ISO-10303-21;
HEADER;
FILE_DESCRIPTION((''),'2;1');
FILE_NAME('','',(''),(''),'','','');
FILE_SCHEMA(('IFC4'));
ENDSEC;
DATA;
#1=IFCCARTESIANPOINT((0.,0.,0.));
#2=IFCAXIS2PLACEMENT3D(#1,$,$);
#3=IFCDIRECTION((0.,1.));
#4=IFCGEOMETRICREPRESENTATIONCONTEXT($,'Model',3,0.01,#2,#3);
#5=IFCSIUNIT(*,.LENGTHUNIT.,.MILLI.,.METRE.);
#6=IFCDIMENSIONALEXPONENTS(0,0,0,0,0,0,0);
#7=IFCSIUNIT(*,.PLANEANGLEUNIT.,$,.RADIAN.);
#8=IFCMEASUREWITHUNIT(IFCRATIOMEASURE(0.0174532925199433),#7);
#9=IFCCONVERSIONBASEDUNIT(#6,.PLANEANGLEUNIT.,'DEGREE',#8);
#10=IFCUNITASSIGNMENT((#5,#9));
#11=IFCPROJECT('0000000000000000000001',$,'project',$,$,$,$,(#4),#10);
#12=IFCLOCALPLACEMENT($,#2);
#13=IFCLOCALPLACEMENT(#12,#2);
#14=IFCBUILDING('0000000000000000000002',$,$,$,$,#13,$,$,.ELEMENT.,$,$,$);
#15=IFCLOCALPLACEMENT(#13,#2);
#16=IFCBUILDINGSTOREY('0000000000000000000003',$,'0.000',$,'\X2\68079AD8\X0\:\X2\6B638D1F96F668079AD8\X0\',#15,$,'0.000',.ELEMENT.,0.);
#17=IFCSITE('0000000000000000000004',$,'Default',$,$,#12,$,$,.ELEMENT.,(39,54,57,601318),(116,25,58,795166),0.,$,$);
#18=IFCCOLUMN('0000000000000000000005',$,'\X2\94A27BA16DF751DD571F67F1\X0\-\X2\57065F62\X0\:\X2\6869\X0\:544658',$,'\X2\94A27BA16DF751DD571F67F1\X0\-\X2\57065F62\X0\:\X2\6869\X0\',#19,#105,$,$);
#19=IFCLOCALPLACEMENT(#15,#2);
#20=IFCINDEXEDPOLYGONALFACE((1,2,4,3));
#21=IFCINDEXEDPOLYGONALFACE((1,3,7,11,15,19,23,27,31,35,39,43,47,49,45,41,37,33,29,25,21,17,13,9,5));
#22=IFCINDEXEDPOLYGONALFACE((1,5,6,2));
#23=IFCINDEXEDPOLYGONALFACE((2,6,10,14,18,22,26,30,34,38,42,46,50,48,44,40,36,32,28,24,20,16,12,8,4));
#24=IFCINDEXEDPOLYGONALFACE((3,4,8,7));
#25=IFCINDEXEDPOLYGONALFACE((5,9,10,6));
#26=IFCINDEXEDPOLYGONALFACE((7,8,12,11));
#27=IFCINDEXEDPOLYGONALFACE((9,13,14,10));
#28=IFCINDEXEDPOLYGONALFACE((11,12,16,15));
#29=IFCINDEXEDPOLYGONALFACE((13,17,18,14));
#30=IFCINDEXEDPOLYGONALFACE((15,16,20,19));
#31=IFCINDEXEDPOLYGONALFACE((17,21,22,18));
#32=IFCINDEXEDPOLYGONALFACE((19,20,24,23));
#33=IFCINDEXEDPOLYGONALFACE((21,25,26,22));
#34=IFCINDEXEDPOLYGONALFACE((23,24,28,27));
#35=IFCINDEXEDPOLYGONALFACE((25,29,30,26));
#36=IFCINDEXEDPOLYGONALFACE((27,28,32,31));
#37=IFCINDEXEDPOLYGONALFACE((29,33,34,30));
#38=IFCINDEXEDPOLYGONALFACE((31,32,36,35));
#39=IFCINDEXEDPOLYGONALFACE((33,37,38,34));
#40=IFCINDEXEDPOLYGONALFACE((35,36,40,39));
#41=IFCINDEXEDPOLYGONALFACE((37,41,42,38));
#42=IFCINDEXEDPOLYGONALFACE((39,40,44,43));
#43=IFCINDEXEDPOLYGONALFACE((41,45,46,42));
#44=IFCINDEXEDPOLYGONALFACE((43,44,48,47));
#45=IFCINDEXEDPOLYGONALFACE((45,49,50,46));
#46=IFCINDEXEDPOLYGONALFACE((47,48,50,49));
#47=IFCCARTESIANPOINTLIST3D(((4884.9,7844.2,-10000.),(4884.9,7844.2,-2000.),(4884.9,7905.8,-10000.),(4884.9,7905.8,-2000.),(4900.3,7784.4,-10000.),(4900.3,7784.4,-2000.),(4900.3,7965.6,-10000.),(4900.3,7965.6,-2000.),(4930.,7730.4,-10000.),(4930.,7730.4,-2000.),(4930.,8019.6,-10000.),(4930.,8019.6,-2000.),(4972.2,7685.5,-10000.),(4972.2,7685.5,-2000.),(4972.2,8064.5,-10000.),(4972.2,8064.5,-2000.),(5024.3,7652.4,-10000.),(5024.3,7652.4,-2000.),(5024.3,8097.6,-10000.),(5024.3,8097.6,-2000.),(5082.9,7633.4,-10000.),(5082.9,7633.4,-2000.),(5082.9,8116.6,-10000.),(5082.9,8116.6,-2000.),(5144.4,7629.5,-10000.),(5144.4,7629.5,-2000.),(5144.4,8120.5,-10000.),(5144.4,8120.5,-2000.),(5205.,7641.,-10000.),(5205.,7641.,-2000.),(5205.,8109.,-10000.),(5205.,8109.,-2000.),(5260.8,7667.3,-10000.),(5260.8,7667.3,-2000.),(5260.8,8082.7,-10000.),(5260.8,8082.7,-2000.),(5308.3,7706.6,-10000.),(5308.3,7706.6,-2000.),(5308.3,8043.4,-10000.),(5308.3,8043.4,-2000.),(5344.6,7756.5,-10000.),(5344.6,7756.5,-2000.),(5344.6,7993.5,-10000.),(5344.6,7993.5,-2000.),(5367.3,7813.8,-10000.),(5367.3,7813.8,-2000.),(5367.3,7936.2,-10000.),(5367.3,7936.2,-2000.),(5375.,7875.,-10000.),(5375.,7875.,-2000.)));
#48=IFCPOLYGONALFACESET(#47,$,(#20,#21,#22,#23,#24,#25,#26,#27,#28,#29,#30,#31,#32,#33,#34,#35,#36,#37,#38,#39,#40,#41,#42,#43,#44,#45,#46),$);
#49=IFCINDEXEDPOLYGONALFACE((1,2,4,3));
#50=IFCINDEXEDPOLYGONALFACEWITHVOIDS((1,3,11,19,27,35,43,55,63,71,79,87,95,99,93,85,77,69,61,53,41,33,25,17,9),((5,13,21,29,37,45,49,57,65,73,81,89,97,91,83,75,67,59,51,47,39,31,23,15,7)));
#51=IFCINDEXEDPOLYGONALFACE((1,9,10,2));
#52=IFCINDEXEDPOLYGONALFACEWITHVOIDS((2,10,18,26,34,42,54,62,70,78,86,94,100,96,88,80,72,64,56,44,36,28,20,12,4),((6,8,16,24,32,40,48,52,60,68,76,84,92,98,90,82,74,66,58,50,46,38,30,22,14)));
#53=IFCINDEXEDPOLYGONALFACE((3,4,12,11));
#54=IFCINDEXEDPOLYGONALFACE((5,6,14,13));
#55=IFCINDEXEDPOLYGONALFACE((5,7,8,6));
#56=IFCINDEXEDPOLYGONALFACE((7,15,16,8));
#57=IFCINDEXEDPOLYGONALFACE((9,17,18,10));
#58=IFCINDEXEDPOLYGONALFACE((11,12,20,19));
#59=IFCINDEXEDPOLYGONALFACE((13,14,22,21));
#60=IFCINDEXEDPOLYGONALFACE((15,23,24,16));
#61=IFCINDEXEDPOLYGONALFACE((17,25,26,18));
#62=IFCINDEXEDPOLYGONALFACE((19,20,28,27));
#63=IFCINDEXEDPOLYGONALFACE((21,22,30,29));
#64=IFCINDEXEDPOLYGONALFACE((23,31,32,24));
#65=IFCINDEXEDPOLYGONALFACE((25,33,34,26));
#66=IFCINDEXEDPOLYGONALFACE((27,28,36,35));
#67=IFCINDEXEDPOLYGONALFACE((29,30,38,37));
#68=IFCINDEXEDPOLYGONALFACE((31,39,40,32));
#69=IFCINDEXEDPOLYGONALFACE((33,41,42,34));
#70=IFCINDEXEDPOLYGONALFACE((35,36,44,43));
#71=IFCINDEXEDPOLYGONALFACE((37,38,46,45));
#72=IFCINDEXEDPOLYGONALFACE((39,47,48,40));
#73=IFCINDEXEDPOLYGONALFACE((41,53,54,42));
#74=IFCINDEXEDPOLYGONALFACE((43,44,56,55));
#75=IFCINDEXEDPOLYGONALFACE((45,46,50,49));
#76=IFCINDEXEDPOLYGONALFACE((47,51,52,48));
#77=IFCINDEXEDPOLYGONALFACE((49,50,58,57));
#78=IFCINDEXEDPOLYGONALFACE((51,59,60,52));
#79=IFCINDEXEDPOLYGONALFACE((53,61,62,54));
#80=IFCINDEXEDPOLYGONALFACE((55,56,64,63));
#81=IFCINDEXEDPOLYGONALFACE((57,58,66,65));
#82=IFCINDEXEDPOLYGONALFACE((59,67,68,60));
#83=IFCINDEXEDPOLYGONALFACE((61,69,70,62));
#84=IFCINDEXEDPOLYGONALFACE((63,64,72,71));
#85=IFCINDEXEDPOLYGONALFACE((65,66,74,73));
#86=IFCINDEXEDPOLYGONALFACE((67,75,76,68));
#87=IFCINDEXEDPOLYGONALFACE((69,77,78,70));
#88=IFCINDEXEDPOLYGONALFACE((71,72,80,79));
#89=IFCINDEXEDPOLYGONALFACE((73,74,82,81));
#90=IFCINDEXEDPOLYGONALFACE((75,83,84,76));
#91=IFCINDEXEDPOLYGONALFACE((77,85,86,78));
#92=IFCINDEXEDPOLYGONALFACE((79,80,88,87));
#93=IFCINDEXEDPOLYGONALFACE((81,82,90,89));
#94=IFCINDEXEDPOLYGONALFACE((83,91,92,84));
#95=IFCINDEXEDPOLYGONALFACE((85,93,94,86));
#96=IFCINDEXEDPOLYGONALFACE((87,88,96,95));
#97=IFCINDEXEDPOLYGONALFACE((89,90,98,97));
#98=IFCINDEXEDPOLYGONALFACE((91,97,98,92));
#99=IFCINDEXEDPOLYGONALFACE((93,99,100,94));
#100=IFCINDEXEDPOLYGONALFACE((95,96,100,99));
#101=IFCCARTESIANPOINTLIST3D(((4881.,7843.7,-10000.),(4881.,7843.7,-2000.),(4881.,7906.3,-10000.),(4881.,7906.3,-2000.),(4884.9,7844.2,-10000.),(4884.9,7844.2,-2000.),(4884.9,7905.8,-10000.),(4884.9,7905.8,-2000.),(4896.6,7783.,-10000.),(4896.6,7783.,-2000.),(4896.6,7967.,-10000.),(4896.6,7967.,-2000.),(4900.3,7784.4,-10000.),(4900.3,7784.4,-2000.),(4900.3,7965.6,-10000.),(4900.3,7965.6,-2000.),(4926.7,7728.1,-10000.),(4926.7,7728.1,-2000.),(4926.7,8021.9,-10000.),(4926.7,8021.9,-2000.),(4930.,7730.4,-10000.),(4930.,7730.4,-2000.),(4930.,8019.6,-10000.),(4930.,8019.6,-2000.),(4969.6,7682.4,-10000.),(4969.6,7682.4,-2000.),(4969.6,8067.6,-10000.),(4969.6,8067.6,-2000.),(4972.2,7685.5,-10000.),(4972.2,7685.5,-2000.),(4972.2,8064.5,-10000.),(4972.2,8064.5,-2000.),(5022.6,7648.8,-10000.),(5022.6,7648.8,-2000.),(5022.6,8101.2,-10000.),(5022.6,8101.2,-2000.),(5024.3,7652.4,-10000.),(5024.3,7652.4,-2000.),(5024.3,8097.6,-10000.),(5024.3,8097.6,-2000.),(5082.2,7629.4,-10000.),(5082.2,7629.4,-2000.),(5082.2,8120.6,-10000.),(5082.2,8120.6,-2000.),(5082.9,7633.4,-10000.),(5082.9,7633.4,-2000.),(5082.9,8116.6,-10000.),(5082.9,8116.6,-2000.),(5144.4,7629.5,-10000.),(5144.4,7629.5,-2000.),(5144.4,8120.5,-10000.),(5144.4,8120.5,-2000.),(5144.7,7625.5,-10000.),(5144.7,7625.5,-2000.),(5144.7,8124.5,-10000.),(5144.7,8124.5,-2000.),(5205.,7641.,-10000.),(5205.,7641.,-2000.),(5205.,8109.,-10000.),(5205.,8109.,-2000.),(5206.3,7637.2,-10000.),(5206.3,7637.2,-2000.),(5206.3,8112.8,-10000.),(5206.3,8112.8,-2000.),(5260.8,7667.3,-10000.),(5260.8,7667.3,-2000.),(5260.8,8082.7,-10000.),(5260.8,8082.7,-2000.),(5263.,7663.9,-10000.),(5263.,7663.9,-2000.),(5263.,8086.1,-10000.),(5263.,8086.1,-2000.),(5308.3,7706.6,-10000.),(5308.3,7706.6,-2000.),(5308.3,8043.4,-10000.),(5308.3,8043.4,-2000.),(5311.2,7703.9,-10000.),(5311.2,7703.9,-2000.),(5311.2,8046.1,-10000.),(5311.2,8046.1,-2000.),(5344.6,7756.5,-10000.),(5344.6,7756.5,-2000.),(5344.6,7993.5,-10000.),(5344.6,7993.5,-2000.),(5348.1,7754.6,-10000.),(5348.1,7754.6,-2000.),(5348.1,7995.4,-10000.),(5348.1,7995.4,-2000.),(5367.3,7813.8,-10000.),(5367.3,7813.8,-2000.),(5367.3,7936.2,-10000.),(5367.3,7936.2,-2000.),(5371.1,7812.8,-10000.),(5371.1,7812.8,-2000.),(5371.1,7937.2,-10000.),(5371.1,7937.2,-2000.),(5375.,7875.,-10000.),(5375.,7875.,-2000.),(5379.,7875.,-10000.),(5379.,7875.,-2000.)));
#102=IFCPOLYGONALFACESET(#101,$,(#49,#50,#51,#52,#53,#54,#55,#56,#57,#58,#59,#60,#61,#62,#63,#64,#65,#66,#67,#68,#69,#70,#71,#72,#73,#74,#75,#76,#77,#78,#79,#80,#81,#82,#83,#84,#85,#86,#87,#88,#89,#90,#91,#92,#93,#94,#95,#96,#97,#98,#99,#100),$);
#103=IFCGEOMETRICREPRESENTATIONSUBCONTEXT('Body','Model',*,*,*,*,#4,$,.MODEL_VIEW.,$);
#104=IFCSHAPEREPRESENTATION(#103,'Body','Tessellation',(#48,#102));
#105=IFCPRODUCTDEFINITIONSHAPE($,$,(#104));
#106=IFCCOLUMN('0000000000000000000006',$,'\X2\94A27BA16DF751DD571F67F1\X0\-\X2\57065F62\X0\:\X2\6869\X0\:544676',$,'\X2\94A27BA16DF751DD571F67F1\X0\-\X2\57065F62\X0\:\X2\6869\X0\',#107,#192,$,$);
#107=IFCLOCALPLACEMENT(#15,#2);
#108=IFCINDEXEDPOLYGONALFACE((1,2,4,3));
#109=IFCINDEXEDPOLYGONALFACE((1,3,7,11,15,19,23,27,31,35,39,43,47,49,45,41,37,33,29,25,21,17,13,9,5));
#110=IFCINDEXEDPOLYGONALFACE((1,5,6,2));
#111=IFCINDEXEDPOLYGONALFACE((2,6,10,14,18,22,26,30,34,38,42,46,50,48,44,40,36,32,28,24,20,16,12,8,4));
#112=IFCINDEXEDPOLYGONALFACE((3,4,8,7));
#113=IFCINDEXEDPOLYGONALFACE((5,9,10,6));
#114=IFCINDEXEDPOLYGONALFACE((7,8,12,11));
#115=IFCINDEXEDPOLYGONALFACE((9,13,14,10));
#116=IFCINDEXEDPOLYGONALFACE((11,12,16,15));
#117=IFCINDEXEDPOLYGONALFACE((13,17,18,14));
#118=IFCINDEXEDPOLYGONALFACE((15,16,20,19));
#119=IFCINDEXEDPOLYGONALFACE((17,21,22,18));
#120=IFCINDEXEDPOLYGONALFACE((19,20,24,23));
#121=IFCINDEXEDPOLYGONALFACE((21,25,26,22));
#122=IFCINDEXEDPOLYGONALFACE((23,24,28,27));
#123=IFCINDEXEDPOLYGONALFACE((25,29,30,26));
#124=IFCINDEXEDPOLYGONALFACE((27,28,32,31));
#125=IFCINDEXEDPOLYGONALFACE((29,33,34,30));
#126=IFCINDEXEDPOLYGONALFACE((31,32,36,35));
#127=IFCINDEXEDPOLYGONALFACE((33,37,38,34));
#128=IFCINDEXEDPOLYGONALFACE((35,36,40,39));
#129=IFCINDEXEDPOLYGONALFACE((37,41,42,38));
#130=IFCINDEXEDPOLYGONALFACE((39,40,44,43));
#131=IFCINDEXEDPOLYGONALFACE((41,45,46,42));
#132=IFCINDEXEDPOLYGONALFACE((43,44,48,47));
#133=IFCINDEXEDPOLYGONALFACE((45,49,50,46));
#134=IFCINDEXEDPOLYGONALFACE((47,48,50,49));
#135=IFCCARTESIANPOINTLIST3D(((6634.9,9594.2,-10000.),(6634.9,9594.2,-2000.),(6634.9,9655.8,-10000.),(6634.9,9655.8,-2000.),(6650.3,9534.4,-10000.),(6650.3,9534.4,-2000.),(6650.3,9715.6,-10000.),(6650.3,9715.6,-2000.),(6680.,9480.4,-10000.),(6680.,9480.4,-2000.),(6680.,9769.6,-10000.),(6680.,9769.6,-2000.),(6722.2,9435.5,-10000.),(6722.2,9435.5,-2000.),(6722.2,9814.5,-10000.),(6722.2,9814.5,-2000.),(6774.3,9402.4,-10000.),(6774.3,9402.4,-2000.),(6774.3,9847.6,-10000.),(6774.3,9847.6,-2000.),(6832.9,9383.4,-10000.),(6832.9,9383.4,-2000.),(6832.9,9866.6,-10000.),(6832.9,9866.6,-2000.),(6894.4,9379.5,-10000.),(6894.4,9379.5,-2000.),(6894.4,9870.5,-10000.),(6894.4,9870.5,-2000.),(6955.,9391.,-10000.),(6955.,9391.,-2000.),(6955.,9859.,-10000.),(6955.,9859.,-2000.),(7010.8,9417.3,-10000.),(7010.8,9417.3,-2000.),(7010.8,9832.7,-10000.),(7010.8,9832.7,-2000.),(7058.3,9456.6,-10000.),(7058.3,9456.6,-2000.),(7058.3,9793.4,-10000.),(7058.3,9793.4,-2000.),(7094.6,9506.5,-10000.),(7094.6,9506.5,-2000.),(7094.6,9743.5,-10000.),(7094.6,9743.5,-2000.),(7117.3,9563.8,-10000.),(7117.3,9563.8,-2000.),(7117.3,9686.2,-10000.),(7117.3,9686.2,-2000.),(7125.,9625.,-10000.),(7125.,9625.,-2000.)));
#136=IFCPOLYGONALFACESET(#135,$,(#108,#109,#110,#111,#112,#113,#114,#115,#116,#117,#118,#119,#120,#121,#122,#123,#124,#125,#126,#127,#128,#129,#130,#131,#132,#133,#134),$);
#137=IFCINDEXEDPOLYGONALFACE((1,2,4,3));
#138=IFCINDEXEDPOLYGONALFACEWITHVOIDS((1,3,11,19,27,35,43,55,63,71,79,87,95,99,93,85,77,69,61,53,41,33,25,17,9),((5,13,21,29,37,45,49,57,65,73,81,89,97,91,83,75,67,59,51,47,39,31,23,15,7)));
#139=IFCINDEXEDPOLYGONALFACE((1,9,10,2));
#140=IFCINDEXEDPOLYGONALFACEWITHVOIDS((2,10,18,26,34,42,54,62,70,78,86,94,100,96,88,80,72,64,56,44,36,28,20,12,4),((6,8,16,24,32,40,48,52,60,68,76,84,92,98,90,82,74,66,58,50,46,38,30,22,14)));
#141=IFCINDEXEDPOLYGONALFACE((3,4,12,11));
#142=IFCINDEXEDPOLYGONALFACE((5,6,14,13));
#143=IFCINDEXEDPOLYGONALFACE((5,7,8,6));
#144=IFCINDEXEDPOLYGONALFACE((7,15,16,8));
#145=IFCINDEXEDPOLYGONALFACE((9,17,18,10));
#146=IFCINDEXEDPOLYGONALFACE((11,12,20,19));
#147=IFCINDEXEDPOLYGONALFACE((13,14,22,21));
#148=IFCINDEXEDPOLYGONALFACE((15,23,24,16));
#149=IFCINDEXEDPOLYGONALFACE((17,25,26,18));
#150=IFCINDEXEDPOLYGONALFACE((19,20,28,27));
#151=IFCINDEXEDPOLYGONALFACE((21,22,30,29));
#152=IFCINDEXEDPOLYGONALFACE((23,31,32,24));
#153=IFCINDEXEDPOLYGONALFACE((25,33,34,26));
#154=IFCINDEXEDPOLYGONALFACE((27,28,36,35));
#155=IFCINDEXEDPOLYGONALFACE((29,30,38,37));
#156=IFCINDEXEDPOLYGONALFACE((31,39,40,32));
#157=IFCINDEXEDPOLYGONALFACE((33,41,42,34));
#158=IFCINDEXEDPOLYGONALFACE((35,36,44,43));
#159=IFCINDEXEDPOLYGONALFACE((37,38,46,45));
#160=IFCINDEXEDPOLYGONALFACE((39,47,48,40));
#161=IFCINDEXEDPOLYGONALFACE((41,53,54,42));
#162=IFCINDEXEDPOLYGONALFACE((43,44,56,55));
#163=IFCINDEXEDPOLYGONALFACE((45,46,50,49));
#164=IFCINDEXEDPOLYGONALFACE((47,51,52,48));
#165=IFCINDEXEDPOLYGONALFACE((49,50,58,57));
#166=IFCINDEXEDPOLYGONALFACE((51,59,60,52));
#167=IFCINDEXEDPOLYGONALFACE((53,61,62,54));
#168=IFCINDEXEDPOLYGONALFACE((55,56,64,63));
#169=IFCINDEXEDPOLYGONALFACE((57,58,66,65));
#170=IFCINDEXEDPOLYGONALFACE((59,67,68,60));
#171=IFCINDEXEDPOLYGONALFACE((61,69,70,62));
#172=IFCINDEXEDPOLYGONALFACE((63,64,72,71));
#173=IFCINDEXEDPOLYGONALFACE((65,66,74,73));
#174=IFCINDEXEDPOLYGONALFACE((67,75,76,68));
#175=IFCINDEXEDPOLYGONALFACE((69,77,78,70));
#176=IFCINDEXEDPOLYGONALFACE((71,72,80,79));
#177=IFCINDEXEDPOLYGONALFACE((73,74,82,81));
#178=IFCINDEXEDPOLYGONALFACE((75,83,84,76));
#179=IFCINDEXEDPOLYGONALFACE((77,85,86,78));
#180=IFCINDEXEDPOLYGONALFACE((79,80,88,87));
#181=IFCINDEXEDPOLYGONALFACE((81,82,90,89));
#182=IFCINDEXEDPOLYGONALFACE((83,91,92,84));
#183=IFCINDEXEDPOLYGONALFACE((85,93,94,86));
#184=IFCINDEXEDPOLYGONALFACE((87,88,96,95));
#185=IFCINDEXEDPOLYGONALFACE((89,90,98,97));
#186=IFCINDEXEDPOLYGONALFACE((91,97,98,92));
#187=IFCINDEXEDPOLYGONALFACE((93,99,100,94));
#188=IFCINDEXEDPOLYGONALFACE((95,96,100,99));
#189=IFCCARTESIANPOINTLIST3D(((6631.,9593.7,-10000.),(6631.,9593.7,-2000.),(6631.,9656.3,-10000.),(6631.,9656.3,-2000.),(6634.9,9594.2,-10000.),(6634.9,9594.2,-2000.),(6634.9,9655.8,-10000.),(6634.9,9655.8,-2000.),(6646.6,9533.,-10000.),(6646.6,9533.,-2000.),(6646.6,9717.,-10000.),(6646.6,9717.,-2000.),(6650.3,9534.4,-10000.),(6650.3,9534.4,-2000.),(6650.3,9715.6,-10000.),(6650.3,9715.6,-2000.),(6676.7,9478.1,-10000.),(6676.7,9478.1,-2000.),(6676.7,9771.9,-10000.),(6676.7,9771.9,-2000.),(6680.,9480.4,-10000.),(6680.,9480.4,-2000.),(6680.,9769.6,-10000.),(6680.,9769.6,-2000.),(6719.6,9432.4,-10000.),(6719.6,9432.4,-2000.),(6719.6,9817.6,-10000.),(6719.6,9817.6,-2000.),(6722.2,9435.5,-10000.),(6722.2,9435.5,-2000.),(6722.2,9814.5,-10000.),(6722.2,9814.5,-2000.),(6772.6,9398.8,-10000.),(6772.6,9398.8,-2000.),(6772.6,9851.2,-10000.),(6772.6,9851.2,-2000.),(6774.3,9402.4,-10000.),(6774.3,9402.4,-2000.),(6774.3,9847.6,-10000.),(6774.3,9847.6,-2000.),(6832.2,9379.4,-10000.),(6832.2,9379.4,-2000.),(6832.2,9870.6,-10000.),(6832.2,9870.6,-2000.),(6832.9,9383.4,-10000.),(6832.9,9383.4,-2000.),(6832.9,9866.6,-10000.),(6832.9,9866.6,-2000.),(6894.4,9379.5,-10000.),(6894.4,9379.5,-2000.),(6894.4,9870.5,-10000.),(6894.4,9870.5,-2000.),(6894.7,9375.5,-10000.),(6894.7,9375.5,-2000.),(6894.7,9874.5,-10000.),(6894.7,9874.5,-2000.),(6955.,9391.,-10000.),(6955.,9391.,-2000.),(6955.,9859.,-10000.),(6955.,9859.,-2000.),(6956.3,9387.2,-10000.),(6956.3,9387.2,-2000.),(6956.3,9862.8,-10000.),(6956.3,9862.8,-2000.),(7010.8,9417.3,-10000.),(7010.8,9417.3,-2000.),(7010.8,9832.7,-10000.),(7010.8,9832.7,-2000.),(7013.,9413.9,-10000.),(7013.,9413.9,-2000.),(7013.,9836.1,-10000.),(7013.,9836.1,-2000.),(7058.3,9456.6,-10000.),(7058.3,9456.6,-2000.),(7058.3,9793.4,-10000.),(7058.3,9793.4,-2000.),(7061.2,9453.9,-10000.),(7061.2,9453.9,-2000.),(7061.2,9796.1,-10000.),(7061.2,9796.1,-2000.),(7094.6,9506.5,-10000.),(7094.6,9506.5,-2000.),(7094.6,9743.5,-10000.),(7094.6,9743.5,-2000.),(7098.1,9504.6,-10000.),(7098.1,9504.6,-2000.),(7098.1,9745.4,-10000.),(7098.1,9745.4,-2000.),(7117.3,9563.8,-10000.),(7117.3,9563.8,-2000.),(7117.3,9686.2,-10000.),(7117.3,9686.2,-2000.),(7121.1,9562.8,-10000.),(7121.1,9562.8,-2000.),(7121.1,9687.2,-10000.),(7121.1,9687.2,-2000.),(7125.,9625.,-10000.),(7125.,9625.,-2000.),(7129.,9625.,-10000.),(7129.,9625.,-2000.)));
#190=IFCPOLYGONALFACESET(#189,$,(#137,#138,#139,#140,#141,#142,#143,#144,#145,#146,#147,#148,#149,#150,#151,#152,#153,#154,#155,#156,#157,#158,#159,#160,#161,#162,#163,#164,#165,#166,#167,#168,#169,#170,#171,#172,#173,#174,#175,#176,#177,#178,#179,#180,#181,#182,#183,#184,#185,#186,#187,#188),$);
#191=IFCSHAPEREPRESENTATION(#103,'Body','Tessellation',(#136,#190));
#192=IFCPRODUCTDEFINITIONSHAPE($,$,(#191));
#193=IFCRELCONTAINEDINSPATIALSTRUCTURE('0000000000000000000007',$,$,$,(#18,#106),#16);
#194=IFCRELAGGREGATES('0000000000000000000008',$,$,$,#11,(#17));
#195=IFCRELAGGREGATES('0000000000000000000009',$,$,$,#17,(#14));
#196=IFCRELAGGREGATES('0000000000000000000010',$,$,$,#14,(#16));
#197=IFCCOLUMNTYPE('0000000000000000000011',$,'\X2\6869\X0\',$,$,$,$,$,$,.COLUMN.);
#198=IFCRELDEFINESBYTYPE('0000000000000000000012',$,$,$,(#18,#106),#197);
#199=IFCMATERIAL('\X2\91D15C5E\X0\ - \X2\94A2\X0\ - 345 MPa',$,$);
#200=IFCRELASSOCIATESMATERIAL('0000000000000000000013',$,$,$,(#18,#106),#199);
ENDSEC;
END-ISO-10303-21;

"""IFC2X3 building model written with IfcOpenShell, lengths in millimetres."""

from ifc_helpers import new_model, entity, si_unit, converted_unit, direction, frame, frame_2d, origin, place, context, subcontext, project, spatial, circle, hollow_circle, extrude, source, transform, mapped, material, type_object, type_shapes, element, save


model = new_model("IFC2X3")

# Units and contexts
model_context = context("Model", 3, precision=0.01, world=origin(), true_north=direction((0.0, 1.0)))
body_context = subcontext(model_context, "Body", "Model", "MODEL_VIEW")
ifc_project = project(units=[si_unit("LENGTHUNIT", "METRE", prefix="MILLI"), converted_unit("PLANEANGLEUNIT", "DEGREE", entity("IfcRatioMeasure", 0.0174532925199433), si_unit("PLANEANGLEUNIT", "RADIAN"), dimensions=[0, 0, 0, 0, 0, 0, 0])], contexts=[model_context])

# Site, building, storey
site_placement = place(None, origin())
site = spatial("IfcSite", under=ifc_project, at=site_placement, Name="Default", CompositionType="ELEMENT", RefLatitude=(39, 54, 57, 601318), RefLongitude=(116, 25, 58, 795166), RefElevation=0.0)
building_placement = place(site_placement, origin())
building = spatial("IfcBuilding", under=site, at=building_placement, CompositionType="ELEMENT")
storey_placement = place(building_placement, origin())
storey = spatial("IfcBuildingStorey", under=building, at=storey_placement, Name="0.000", ObjectType="标高:正负零标高", LongName="0.000", CompositionType="ELEMENT", Elevation=0.0)

# Columns
ifc_material_1 = material(Name="金属 - 钢 - 345 MPa")
column_type = type_object("IfcColumnType", Name="桩", PredefinedType="COLUMN")
shared_shape = source(origin(), body_context, "Body", "SweptSolid", [
    extrude(circle(Radius=246.0, at=frame_2d((0.0, 0.0), x_axis=(1.0, 0.0))), frame((0.0, 0.0, -10000.0)), (0.0, 0.0, 1.0), 8000.0),
    extrude(hollow_circle(Radius=250.0, WallThickness=4.0, at=frame_2d((0.0, 0.0), x_axis=(1.0, 0.0))), frame((0.0, 0.0, -10000.0)), (0.0, 0.0, 1.0), 8000.0),
])
type_shapes(column_type, [shared_shape])
for number, where, name in (
    (1, (5129.0, 7875.0, 0.0), "钢管混凝土柱-圆形:桩:544658"),
    (2, (6879.0, 9625.0, 0.0), "钢管混凝土柱-圆形:桩:544676"),
):
    element("IfcColumn", number, at=place(storey_placement, frame(where)), inside=storey, type_object=column_type, material=ifc_material_1, Name=name, ObjectType="钢管混凝土柱-圆形:桩", context=body_context, shape_type="MappedRepresentation", body=[
        mapped(shared_shape, transform((0.0, 0.0, 0.0), scale=1.0)),
    ])

save(model, "model.ifc")
